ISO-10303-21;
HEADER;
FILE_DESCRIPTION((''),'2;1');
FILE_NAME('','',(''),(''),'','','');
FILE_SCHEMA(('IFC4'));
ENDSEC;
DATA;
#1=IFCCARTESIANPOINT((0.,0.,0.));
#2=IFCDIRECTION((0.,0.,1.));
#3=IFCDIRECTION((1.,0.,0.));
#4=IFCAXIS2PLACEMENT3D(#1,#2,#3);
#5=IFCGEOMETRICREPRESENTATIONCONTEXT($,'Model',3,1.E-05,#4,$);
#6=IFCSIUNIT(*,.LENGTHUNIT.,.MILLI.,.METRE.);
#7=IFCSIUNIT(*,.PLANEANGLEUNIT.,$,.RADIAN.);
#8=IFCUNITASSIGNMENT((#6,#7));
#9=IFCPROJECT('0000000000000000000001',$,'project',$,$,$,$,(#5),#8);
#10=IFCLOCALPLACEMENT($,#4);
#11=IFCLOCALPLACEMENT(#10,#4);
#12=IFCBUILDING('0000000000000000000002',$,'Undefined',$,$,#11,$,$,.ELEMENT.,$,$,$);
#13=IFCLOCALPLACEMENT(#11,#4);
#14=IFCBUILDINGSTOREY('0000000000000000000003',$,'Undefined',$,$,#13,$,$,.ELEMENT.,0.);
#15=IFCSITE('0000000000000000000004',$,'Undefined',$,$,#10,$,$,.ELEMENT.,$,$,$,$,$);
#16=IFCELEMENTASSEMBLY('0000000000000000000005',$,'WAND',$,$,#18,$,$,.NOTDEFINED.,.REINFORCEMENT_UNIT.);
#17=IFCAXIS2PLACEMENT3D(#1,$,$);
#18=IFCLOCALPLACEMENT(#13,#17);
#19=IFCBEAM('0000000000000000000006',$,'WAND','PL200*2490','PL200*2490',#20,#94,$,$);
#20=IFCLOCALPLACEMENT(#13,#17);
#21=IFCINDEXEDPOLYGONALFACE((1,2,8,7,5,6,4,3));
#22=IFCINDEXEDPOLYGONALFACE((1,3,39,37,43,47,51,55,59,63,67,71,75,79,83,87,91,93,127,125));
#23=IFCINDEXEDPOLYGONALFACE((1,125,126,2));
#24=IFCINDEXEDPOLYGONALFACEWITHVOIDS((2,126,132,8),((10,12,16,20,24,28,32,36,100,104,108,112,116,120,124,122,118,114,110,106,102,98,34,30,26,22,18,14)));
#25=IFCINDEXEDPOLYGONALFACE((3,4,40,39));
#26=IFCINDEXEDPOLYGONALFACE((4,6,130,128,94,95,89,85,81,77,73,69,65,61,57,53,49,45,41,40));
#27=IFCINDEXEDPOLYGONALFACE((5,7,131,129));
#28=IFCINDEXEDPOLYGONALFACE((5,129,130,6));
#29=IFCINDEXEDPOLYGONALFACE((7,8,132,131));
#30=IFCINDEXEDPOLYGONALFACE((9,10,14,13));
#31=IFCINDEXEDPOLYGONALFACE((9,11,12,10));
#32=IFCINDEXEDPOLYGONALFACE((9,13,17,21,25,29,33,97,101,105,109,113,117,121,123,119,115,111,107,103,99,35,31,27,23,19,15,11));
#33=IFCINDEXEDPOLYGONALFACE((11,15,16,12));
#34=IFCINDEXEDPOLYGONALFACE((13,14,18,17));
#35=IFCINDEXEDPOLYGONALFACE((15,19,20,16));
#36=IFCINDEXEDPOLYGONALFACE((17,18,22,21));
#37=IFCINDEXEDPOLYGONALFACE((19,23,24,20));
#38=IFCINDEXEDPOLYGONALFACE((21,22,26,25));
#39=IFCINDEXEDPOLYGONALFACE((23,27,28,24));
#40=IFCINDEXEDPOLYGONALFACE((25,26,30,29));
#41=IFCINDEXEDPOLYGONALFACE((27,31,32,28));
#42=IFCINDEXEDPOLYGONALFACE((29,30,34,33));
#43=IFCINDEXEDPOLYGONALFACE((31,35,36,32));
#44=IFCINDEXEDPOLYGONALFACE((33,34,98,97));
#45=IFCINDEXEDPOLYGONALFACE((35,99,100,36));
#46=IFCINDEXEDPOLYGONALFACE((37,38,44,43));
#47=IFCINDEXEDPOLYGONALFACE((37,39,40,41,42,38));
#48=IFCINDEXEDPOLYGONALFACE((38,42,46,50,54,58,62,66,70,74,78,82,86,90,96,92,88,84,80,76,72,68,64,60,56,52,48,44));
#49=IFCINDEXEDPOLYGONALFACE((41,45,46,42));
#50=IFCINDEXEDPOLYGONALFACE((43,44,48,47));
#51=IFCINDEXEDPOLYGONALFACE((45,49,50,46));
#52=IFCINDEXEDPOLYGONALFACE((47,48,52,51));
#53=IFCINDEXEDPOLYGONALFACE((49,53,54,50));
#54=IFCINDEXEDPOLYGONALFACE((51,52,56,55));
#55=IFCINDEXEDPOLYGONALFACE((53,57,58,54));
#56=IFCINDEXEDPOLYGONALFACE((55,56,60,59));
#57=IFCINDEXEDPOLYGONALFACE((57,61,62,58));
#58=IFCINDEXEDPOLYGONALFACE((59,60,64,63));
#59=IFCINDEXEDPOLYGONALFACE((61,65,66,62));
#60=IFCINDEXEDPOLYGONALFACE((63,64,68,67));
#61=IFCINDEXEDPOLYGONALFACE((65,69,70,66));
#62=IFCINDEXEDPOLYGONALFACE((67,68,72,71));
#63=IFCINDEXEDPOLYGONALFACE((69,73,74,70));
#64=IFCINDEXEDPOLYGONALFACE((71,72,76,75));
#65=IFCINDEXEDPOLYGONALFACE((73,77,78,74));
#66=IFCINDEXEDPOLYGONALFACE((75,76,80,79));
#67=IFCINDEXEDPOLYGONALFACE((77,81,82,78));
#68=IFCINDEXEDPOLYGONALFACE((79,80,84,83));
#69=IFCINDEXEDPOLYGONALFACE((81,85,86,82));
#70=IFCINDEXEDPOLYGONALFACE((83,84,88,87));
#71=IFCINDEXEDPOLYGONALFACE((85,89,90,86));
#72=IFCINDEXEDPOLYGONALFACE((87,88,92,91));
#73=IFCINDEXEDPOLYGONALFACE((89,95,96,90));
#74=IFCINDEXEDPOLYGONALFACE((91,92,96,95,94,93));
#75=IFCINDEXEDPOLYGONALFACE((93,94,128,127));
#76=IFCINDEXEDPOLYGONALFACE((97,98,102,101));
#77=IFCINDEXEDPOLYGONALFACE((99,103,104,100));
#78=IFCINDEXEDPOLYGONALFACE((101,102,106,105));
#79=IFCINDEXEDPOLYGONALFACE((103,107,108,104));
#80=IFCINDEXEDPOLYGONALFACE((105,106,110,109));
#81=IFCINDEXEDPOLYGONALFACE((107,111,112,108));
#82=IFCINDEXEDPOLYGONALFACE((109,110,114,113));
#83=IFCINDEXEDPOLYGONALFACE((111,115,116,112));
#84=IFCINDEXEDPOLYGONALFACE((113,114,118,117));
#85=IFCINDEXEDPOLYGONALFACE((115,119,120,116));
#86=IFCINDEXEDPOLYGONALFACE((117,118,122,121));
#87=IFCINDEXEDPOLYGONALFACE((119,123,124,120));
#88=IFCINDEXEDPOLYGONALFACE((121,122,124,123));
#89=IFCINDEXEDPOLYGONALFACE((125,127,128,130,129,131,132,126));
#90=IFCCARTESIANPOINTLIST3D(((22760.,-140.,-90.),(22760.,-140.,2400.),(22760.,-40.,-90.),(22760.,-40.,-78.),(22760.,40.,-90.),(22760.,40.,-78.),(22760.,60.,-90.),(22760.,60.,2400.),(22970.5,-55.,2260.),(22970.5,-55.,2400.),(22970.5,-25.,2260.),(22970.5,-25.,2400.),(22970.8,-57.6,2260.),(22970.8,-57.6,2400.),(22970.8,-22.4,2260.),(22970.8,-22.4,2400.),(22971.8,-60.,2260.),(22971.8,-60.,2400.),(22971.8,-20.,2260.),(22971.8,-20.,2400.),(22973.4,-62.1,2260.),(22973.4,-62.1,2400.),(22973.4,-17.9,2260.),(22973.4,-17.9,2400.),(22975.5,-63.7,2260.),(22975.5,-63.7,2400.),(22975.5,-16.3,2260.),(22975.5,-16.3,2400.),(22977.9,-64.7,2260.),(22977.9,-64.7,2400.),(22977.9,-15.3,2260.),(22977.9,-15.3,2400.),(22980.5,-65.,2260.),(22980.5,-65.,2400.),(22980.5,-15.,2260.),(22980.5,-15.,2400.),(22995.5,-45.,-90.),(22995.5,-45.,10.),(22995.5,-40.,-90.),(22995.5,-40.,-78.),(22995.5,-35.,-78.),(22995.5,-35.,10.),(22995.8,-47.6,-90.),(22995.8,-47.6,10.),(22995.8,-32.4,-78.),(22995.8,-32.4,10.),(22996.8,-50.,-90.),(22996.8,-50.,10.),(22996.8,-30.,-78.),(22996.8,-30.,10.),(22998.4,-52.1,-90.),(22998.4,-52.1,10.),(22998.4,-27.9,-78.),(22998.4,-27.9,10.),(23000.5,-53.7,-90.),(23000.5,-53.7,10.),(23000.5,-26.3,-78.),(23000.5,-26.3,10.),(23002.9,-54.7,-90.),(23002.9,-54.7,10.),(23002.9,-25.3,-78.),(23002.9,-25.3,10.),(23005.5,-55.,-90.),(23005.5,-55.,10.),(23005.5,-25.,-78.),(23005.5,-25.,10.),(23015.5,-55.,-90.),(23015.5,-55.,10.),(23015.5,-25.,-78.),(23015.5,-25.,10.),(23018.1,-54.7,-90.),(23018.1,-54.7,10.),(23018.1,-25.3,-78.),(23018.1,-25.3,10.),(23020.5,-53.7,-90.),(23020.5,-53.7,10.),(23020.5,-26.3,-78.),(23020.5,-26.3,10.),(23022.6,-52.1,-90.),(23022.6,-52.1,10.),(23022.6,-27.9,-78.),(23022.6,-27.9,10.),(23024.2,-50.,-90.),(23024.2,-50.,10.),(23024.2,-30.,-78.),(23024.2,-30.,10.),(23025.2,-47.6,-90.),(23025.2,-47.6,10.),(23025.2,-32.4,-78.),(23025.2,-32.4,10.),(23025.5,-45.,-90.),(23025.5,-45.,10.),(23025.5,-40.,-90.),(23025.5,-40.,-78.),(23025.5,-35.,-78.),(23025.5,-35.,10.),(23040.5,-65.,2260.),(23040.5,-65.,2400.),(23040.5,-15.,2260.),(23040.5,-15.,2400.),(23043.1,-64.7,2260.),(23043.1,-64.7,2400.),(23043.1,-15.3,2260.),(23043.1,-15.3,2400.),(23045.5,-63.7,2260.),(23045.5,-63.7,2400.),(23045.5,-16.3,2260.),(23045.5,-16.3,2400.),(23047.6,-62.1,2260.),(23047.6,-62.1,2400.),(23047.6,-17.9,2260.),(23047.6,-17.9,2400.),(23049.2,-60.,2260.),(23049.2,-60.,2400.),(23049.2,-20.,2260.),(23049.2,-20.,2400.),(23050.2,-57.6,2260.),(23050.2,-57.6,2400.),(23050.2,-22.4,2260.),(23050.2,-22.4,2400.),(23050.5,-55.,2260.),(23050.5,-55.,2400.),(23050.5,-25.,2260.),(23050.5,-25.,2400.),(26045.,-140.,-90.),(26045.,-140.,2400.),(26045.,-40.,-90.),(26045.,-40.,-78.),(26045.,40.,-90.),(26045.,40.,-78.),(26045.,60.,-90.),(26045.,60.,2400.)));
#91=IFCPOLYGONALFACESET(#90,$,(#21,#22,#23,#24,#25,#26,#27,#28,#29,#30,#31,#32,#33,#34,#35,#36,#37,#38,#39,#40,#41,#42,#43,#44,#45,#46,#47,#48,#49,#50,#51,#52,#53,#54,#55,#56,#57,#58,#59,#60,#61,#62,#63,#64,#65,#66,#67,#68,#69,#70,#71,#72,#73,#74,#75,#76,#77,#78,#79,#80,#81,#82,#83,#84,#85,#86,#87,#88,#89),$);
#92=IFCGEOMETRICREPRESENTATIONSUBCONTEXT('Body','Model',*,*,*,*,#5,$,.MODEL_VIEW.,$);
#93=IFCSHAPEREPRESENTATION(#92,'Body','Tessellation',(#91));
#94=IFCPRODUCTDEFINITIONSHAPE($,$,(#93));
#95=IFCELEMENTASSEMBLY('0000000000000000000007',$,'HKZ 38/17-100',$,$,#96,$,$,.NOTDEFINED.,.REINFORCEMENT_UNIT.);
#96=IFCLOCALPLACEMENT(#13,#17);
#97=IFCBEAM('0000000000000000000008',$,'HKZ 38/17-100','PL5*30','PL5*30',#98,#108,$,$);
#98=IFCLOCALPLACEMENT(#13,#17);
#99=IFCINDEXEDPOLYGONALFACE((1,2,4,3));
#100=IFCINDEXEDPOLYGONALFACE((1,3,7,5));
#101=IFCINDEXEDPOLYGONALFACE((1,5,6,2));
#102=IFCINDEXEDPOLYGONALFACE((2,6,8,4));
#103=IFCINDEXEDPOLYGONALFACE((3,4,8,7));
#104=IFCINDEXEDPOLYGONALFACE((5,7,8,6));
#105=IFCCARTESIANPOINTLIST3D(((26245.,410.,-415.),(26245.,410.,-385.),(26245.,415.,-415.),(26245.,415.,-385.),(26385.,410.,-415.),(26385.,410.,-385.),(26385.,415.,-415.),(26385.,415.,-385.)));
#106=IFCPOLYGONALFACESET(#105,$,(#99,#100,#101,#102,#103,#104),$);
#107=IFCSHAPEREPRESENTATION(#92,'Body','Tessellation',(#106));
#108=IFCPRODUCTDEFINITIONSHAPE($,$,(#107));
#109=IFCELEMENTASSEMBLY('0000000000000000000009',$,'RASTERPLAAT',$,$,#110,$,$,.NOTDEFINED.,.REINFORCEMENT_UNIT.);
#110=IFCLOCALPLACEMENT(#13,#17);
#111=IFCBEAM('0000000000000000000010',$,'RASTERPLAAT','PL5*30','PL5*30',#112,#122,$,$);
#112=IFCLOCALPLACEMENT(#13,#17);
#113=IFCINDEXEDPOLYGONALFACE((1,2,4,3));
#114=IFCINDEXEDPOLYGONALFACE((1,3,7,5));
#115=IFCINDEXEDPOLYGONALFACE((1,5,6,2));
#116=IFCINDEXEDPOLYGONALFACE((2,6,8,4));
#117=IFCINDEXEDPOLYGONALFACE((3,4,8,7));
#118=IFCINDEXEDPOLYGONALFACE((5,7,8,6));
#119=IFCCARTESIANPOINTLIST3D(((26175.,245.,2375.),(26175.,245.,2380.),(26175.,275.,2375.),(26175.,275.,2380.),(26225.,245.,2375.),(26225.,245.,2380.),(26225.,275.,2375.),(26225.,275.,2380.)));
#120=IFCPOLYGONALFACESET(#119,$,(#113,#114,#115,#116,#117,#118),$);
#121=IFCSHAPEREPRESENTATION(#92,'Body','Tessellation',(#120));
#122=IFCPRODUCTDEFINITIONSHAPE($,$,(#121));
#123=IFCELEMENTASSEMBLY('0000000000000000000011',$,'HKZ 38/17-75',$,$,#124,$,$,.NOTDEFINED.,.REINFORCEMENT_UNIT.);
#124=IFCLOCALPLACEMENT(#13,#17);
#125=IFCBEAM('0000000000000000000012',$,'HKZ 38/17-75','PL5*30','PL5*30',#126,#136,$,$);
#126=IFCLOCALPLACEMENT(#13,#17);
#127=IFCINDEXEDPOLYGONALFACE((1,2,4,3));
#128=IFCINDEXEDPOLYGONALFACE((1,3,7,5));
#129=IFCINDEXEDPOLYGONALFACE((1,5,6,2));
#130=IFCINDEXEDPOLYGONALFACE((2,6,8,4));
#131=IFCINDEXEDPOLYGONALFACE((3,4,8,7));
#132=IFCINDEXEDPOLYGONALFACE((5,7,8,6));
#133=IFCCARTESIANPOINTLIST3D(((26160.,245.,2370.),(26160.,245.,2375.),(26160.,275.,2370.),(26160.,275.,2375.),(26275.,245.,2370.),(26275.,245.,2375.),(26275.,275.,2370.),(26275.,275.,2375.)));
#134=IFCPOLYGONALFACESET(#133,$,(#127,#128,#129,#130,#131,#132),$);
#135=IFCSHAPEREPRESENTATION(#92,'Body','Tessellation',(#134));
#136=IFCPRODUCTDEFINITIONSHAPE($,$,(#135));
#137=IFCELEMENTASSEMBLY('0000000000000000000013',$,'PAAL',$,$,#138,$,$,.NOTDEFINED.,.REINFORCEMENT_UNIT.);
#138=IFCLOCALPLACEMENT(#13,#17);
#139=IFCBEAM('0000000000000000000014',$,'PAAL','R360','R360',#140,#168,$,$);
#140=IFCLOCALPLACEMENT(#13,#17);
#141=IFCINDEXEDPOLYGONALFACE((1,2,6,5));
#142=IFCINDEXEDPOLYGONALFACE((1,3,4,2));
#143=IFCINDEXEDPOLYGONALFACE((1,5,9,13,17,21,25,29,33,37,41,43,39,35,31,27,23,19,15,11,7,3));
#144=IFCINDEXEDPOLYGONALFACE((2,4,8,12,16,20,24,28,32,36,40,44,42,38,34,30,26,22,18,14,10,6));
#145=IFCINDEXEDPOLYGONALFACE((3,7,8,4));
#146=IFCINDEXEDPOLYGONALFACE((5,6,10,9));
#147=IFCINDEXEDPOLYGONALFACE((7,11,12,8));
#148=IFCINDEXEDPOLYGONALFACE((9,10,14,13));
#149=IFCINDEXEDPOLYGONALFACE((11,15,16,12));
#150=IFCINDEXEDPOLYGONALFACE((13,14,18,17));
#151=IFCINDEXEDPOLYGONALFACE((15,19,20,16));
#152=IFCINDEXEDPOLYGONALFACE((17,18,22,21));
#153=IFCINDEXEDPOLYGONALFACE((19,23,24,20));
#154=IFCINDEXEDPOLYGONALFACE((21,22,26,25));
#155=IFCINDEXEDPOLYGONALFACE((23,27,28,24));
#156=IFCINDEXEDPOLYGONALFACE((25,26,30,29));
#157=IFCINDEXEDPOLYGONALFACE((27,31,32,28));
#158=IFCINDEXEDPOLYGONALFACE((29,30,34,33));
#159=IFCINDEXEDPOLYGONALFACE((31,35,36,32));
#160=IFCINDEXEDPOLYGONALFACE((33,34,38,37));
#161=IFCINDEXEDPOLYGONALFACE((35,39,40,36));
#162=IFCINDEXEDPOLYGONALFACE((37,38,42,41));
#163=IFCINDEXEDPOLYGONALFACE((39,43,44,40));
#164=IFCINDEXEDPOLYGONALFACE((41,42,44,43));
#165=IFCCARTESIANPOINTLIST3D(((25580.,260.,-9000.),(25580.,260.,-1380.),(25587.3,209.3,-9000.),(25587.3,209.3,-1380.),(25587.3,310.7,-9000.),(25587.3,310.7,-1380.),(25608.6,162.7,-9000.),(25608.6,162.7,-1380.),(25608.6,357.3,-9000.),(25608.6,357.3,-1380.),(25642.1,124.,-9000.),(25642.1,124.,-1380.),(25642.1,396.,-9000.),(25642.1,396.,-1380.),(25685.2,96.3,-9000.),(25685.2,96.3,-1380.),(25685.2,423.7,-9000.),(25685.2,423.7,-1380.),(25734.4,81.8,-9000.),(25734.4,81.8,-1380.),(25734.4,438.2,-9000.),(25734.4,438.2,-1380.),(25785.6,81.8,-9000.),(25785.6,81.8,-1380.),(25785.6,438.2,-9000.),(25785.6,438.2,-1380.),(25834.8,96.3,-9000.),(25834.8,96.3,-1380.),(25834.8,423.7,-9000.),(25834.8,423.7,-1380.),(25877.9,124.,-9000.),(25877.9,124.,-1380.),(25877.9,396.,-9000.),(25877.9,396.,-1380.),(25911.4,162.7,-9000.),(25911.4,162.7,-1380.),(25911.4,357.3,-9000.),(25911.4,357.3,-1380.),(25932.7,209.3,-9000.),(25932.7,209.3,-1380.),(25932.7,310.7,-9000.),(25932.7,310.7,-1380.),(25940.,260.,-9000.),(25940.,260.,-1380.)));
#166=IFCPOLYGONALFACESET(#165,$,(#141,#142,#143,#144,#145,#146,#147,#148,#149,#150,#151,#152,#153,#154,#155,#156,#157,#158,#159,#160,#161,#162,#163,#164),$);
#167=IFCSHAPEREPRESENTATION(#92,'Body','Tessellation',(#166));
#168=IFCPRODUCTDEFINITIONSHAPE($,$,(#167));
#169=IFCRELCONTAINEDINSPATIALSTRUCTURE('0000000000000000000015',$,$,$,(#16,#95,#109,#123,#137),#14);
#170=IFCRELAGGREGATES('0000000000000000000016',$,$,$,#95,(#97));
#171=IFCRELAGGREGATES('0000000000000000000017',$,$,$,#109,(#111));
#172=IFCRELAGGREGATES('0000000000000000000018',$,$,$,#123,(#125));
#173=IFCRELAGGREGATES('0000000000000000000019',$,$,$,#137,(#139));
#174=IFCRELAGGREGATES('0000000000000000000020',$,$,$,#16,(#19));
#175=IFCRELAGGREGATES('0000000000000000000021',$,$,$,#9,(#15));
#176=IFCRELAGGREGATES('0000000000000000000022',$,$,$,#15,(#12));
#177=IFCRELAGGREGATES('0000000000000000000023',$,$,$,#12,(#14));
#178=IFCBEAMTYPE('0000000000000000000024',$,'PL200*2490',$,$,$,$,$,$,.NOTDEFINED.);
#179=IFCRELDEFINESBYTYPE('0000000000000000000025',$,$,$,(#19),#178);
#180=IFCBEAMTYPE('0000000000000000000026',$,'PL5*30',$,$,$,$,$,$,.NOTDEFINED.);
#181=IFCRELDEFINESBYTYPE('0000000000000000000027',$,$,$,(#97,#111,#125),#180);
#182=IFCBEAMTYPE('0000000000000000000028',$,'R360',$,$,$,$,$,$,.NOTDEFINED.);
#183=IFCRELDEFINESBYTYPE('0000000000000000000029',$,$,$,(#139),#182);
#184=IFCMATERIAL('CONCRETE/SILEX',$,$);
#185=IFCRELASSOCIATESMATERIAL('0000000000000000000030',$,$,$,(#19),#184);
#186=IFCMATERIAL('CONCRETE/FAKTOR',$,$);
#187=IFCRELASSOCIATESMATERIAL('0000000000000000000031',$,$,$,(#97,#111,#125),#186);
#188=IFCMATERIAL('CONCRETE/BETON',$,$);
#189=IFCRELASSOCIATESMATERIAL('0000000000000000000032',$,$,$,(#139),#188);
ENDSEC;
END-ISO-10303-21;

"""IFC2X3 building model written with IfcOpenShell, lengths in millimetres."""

from ifc_helpers import new_model, si_unit, frame, frame_2d, origin_with_axes, place, context, subcontext, project, spatial, polyline, circle_curve, parameter, trimmed, segment, composite_curve, rectangle, circle, outline, extrude, boolean, material, type_object, element, aggregate, save


model = new_model("IFC2X3")

# Units and contexts
model_context = context("Model", 3, precision=1e-05, world=origin_with_axes())
body_context = subcontext(model_context, "Body", "Model", "MODEL_VIEW")
ifc_project = project(units=[si_unit("LENGTHUNIT", "METRE", prefix="MILLI"), si_unit("PLANEANGLEUNIT", "RADIAN")], contexts=[model_context])

# Site, building, storey
site_placement = place(None, origin_with_axes())
site = spatial("IfcSite", under=ifc_project, at=site_placement, Name="Undefined", CompositionType="ELEMENT")
building_placement = place(site_placement, origin_with_axes())
building = spatial("IfcBuilding", under=site, at=building_placement, Name="Undefined", CompositionType="ELEMENT")
storey_placement = place(building_placement, origin_with_axes())
storey = spatial("IfcBuildingStorey", under=building, at=storey_placement, Name="Undefined", CompositionType="ELEMENT", Elevation=0.0)

# Shared definitions
ifc_material_1 = material(Name="CONCRETE/FAKTOR")

# Element assembly
assembly_1_placement = place(storey_placement, origin_with_axes())
assembly_1 = element("IfcElementAssembly", 1, at=assembly_1_placement, inside=storey, Name="WAND", AssemblyPlace="NOTDEFINED", PredefinedType="REINFORCEMENT_UNIT")
ifc_material_2 = material(Name="CONCRETE/SILEX")

# Beam
beam_type_1 = type_object("IfcBeamType", Name="PL200*2490", PredefinedType="NOTDEFINED")
beam_1_placement = place(assembly_1_placement, frame((22760.0, -40.0, 1155.0), z_axis=(0.0, 0.0, 1.0), x_axis=(1.0, 0.0, 0.0)))
beam_1 = element("IfcBeam", 2, at=beam_1_placement, type_object=beam_type_1, material=ifc_material_2, Name="WAND", Description="PL200*2490", ObjectType="PL200*2490", context=body_context, shape_type="CSG", body=[
    boolean("DIFFERENCE", boolean("DIFFERENCE", boolean("DIFFERENCE", extrude(rectangle(XDim=200.0, YDim=2490.0, at=frame_2d((0.0, 0.0), x_axis=(1.0, 0.0))), frame((3285.0, 0.0, 0.0), z_axis=(-1.0, 0.0, 0.0), x_axis=(0.0, -1.0, 0.0)), (0.0, 0.0, 1.0), 3285.0), extrude(outline(composite_curve([segment(trimmed(circle_curve(frame_2d((10.0, 10.0), x_axis=(-1.0, 0.0)), 10.0), [parameter(0.0)], [parameter(1.570796)], True, "PARAMETER"), True, "CONTINUOUS"), segment(polyline([(10.0, 0.0), (40.0, 0.0)]), True, "CONTINUOUS"), segment(trimmed(circle_curve(frame_2d((40.0, 10.0), x_axis=(0.0, -1.0)), 10.0), [parameter(0.0)], [parameter(1.570796)], True, "PARAMETER"), True, "CONTINUOUS"), segment(polyline([(50.0, 10.0), (50.0, 70.0)]), True, "CONTINUOUS"), segment(trimmed(circle_curve(frame_2d((40.0, 70.0), x_axis=(1.0, 0.0)), 10.0), [parameter(0.0)], [parameter(1.570796)], True, "PARAMETER"), True, "CONTINUOUS"), segment(polyline([(40.0, 80.0), (10.0, 80.0)]), True, "CONTINUOUS"), segment(trimmed(circle_curve(frame_2d((10.0, 70.0), x_axis=(0.0, 1.0)), 10.0), [parameter(0.0)], [parameter(1.570796)], True, "PARAMETER"), True, "CONTINUOUS"), segment(polyline([(0.0, 70.0), (0.0, 10.0)]), True, "CONTINUOUS")], self_intersect=True)), frame((290.5, -25.0, 1105.0), z_axis=(0.0, 0.0, 1.0), x_axis=(0.0, 1.0, 0.0)), (0.0, 0.0, 1.0), 150.0)), extrude(outline(composite_curve([segment(trimmed(circle_curve(frame_2d((10.0, 10.0), x_axis=(-1.0, 0.0)), 10.0), [parameter(0.0)], [parameter(1.570796)], True, "PARAMETER"), True, "CONTINUOUS"), segment(polyline([(10.0, 0.0), (20.0, 0.0)]), True, "CONTINUOUS"), segment(trimmed(circle_curve(frame_2d((20.0, 10.0), x_axis=(0.0, -1.0)), 10.0), [parameter(0.0)], [parameter(1.570796)], True, "PARAMETER"), True, "CONTINUOUS"), segment(polyline([(30.0, 10.0), (30.0, 20.0)]), True, "CONTINUOUS"), segment(trimmed(circle_curve(frame_2d((20.0, 20.0), x_axis=(1.0, 0.0)), 10.0), [parameter(0.0)], [parameter(1.570796)], True, "PARAMETER"), True, "CONTINUOUS"), segment(polyline([(20.0, 30.0), (10.0, 30.0)]), True, "CONTINUOUS"), segment(trimmed(circle_curve(frame_2d((10.0, 20.0), x_axis=(0.0, 1.0)), 10.0), [parameter(0.0)], [parameter(1.570796)], True, "PARAMETER"), True, "CONTINUOUS"), segment(polyline([(0.0, 20.0), (0.0, 10.0)]), True, "CONTINUOUS")], self_intersect=True)), frame((235.5, 15.0, -1245.0), z_axis=(0.0, 0.0, 1.0), x_axis=(0.0, -1.0, 0.0)), (0.0, 0.0, 1.0), 100.0)), extrude(rectangle(XDim=12.0, YDim=80.0, at=frame_2d((0.0, 0.0), x_axis=(1.0, 0.0))), frame((8585.0, 40.0, -1239.0), z_axis=(-1.0, 0.0, 0.0), x_axis=(0.0, 0.0, -1.0)), (0.0, 0.0, 1.0), 8585.0)),
])

# Element assemblies, beams
assembly_2_placement = place(storey_placement, origin_with_axes())
assembly_2 = element("IfcElementAssembly", 3, at=assembly_2_placement, inside=storey, Name="HKZ 38/17-100", AssemblyPlace="NOTDEFINED", PredefinedType="REINFORCEMENT_UNIT")
beam_type_2 = type_object("IfcBeamType", Name="PL5*30", PredefinedType="NOTDEFINED")
beam_2_placement = place(assembly_2_placement, frame((26245.0, 412.5, -400.0), z_axis=(0.0, 0.0, -1.0), x_axis=(1.0, 0.0, 0.0)))
beam_2 = element("IfcBeam", 4, at=beam_2_placement, type_object=beam_type_2, material=ifc_material_1, Name="HKZ 38/17-100", Description="PL5*30", ObjectType="PL5*30", context=body_context, shape_type="SweptSolid", body=[
    extrude(rectangle(XDim=5.0, YDim=30.0, at=frame_2d((0.0, 0.0), x_axis=(1.0, 0.0))), frame((140.0, 0.0, 0.0), z_axis=(-1.0, 0.0, 0.0), x_axis=(0.0, -1.0, 0.0)), (0.0, 0.0, 1.0), 140.0),
])
aggregate(assembly_2, [beam_2])
assembly_3_placement = place(storey_placement, origin_with_axes())
assembly_3 = element("IfcElementAssembly", 5, at=assembly_3_placement, inside=storey, Name="RASTERPLAAT", AssemblyPlace="NOTDEFINED", PredefinedType="REINFORCEMENT_UNIT")
beam_3_placement = place(assembly_3_placement, frame((26225.0, 260.0, 2377.5), z_axis=(0.0, -1.0, 0.0), x_axis=(-1.0, 0.0, 0.0)))
beam_3 = element("IfcBeam", 6, at=beam_3_placement, type_object=beam_type_2, material=ifc_material_1, Name="RASTERPLAAT", Description="PL5*30", ObjectType="PL5*30", context=body_context, shape_type="SweptSolid", body=[
    extrude(rectangle(XDim=5.0, YDim=30.0, at=frame_2d((0.0, 0.0), x_axis=(1.0, 0.0))), frame((50.0, 0.0, 0.0), z_axis=(-1.0, 0.0, 0.0), x_axis=(0.0, -1.0, 0.0)), (0.0, 0.0, 1.0), 50.0),
])
aggregate(assembly_3, [beam_3])
assembly_4_placement = place(storey_placement, origin_with_axes())
assembly_4 = element("IfcElementAssembly", 7, at=assembly_4_placement, inside=storey, Name="HKZ 38/17-75", AssemblyPlace="NOTDEFINED", PredefinedType="REINFORCEMENT_UNIT")
beam_4_placement = place(assembly_4_placement, frame((26275.0, 260.0, 2372.5), z_axis=(0.0, -1.0, 0.0), x_axis=(-1.0, 0.0, 0.0)))
beam_4 = element("IfcBeam", 8, at=beam_4_placement, type_object=beam_type_2, material=ifc_material_1, Name="HKZ 38/17-75", Description="PL5*30", ObjectType="PL5*30", context=body_context, shape_type="SweptSolid", body=[
    extrude(rectangle(XDim=5.0, YDim=30.0, at=frame_2d((0.0, 0.0), x_axis=(1.0, 0.0))), frame((115.0, 0.0, 0.0), z_axis=(-1.0, 0.0, 0.0), x_axis=(0.0, -1.0, 0.0)), (0.0, 0.0, 1.0), 115.0),
])
aggregate(assembly_4, [beam_4])
assembly_5_placement = place(storey_placement, origin_with_axes())
assembly_5 = element("IfcElementAssembly", 9, at=assembly_5_placement, inside=storey, Name="PAAL", AssemblyPlace="NOTDEFINED", PredefinedType="REINFORCEMENT_UNIT")
ifc_material_3 = material(Name="CONCRETE/BETON")
beam_type_3 = type_object("IfcBeamType", Name="R360", PredefinedType="NOTDEFINED")
beam_5_placement = place(assembly_5_placement, frame((25760.0, 260.0, -1380.0), z_axis=(0.0, -1.0, 0.0), x_axis=(0.0, 0.0, -1.0)))
beam_5 = element("IfcBeam", 10, at=beam_5_placement, type_object=beam_type_3, material=ifc_material_3, Name="PAAL", Description="R360", ObjectType="R360", context=body_context, shape_type="SweptSolid", body=[
    extrude(circle(Radius=180.0, at=frame_2d((0.0, 0.0), x_axis=(1.0, 0.0))), frame((7620.0, 0.0, 0.0), z_axis=(-1.0, 0.0, 0.0), x_axis=(0.0, -1.0, 0.0)), (0.0, 0.0, 1.0), 7620.0),
])
aggregate(assembly_5, [beam_5])

aggregate(assembly_1, [beam_1])

save(model, "model.ifc")
